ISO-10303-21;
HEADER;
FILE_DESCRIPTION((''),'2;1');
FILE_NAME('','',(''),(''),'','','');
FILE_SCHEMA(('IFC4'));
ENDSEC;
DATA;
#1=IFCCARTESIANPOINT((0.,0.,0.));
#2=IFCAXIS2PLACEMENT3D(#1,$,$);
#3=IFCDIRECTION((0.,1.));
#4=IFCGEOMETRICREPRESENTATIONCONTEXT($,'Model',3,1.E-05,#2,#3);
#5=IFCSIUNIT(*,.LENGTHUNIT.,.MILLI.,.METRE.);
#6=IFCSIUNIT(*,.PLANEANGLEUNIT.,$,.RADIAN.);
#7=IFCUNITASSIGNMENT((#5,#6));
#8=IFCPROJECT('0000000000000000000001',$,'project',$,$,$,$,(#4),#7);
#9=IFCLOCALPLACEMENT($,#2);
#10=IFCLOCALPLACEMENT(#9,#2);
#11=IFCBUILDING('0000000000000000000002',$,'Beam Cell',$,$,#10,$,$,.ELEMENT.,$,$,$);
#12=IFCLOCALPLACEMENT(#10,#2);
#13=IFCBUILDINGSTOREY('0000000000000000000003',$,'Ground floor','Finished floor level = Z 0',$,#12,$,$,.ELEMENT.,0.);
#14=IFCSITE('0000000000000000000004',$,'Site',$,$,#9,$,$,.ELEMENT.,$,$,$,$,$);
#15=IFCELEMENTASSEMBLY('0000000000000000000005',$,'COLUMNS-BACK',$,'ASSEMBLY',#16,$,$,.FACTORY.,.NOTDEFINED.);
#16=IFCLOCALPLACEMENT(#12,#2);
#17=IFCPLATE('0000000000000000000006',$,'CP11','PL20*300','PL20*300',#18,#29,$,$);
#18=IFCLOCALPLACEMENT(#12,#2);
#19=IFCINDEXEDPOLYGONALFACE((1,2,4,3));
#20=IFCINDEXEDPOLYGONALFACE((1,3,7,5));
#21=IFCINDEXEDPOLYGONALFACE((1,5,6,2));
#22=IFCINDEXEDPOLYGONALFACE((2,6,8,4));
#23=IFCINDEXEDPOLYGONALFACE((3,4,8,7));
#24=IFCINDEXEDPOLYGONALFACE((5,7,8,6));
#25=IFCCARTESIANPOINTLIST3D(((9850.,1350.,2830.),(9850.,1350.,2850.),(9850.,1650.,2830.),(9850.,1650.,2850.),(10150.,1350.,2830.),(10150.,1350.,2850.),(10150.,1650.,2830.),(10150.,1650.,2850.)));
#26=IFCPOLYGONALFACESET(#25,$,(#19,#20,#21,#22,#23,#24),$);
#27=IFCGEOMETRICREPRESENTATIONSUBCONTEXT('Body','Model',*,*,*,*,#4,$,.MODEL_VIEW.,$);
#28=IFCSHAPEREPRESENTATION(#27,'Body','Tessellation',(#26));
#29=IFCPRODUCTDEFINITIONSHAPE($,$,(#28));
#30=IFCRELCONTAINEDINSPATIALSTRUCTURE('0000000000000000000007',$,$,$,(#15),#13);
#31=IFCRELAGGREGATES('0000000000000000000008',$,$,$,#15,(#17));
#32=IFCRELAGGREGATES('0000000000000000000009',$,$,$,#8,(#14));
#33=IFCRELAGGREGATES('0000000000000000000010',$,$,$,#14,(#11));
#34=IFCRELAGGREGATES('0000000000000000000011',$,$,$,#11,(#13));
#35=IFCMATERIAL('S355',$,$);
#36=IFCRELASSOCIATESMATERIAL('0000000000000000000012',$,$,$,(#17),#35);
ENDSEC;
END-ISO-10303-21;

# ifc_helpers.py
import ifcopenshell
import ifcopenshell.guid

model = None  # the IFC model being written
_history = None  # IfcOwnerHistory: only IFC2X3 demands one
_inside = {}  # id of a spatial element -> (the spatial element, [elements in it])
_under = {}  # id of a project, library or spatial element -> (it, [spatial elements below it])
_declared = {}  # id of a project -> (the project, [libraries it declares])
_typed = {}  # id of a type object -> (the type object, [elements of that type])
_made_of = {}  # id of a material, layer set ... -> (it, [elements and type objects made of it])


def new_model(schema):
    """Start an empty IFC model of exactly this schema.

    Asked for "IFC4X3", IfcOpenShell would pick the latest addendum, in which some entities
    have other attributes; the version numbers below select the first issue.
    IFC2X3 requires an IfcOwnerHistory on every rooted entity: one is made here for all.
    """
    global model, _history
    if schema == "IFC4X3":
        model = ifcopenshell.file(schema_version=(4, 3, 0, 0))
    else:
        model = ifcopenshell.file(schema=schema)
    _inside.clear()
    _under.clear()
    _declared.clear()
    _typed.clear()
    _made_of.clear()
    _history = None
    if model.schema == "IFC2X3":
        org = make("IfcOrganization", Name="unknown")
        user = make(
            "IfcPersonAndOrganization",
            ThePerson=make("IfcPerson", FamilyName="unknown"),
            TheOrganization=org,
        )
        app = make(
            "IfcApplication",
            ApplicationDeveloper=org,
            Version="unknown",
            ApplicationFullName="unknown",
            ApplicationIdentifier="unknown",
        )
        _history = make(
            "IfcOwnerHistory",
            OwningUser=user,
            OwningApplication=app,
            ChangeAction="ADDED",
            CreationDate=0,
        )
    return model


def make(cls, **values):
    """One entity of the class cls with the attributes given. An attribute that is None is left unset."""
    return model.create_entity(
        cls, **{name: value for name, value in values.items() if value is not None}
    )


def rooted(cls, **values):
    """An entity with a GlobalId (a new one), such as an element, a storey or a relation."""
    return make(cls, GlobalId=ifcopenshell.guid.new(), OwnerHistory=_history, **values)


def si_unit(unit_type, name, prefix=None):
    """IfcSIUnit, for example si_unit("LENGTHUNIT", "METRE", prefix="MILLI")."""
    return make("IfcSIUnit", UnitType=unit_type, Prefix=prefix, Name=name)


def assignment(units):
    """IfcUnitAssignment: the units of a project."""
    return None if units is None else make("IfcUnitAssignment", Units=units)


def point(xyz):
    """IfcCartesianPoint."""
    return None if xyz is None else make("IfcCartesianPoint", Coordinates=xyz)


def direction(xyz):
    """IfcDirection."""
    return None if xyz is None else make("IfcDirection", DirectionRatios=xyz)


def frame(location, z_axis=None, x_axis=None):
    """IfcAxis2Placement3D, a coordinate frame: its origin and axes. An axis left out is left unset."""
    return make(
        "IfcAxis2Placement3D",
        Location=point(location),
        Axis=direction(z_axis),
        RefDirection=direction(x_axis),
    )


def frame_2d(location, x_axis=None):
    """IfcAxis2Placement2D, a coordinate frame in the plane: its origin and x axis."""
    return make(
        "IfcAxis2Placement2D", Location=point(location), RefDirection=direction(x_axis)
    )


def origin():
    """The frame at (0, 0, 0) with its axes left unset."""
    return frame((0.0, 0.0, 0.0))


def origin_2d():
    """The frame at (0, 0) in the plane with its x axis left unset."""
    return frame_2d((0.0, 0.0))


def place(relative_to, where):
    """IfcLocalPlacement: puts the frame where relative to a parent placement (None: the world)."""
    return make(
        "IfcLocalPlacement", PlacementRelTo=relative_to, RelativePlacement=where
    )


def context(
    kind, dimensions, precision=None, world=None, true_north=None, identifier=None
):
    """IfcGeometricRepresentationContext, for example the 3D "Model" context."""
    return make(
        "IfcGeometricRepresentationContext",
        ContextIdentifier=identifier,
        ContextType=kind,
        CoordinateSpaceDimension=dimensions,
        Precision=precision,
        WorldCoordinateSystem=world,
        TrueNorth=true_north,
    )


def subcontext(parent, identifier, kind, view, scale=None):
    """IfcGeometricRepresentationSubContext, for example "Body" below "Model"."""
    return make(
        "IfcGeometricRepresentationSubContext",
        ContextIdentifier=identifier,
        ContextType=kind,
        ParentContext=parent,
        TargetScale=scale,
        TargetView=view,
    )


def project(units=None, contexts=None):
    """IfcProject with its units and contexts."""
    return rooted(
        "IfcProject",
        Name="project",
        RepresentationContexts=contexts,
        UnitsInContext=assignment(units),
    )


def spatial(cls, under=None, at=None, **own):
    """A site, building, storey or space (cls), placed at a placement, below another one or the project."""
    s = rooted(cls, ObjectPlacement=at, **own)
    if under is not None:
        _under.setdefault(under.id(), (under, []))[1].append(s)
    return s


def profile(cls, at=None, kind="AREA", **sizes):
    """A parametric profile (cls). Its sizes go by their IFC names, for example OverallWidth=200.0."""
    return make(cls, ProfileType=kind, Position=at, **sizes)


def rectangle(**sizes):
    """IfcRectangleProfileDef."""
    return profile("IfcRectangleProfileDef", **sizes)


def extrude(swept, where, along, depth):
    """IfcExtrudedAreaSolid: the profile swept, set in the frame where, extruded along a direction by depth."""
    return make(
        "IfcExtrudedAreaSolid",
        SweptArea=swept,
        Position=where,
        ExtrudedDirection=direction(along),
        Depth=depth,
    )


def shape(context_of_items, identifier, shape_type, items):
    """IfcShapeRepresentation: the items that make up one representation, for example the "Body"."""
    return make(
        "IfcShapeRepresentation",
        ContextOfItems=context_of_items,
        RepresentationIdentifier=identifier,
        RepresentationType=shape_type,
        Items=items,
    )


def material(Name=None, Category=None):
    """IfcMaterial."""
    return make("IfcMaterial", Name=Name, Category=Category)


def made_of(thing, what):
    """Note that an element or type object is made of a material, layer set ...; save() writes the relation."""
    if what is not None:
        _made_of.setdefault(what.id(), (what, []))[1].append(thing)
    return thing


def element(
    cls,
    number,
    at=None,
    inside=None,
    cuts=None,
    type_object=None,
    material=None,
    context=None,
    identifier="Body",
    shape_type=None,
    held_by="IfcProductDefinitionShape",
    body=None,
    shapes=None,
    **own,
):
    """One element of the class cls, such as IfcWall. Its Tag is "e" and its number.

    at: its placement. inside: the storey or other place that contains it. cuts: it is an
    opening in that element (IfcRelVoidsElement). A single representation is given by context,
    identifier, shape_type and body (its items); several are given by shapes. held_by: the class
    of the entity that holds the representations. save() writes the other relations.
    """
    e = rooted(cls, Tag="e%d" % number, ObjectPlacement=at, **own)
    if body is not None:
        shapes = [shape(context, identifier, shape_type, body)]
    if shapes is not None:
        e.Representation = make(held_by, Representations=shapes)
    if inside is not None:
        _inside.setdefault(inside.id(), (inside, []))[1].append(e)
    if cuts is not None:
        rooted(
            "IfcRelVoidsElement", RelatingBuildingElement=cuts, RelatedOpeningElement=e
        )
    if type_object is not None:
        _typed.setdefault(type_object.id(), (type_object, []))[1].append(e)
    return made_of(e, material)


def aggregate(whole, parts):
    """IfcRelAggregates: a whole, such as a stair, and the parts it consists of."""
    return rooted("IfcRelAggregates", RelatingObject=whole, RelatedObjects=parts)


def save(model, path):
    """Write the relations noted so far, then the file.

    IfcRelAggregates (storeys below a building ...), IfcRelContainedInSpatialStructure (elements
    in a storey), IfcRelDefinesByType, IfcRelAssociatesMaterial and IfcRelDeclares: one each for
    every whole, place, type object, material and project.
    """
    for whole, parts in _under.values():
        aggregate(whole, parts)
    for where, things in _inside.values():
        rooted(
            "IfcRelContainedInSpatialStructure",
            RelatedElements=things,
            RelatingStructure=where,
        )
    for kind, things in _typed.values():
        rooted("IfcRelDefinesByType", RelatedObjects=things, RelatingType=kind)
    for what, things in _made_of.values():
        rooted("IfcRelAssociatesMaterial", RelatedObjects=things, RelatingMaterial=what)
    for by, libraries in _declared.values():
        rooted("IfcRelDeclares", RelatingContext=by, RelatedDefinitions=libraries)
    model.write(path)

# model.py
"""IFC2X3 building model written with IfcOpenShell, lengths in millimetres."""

from ifc_helpers import new_model, si_unit, direction, frame, origin, origin_2d, place, context, subcontext, project, spatial, rectangle, extrude, material, element, aggregate, save


model = new_model("IFC2X3")

# Units and contexts
model_context = context("Model", 3, precision=1e-05, world=origin(), true_north=direction((0.0, 1.0)))
body_context = subcontext(model_context, "Body", "Model", "MODEL_VIEW")
ifc_project = project(units=[si_unit("LENGTHUNIT", "METRE", prefix="MILLI"), si_unit("PLANEANGLEUNIT", "RADIAN")], contexts=[model_context])

# Site, building, storey
site_placement = place(None, origin())
site = spatial("IfcSite", under=ifc_project, at=site_placement, Name="Site", CompositionType="ELEMENT")
building_placement = place(site_placement, origin())
building = spatial("IfcBuilding", under=site, at=building_placement, Name="Beam Cell", CompositionType="ELEMENT")
storey_placement = place(building_placement, origin())
storey = spatial("IfcBuildingStorey", under=building, at=storey_placement, Name="Ground floor", Description="Finished floor level = Z 0", CompositionType="ELEMENT", Elevation=0.0)

# Element assembly
ifc_material = material(Name="S355")
assembly_1_placement = place(storey_placement, origin())
assembly_1 = element("IfcElementAssembly", 1, at=assembly_1_placement, inside=storey, Name="COLUMNS-BACK", ObjectType="ASSEMBLY", AssemblyPlace="FACTORY", PredefinedType="NOTDEFINED")

# Plate
plate_1_placement = place(storey_placement, frame((10000.0, 1500.0, 2830.0), z_axis=(0.0, 0.0, 1.0), x_axis=(1.0, 0.0, 0.0)))
plate_1 = element("IfcPlate", 2, at=plate_1_placement, material=ifc_material, Name="CP11", Description="PL20*300", ObjectType="PL20*300", context=body_context, shape_type="SweptSolid", body=[
    extrude(rectangle(XDim=300.0, YDim=300.0, at=origin_2d()), origin(), (0.0, 0.0, 1.0), 20.0),
])
aggregate(assembly_1, [plate_1])

save(model, "model.ifc")
